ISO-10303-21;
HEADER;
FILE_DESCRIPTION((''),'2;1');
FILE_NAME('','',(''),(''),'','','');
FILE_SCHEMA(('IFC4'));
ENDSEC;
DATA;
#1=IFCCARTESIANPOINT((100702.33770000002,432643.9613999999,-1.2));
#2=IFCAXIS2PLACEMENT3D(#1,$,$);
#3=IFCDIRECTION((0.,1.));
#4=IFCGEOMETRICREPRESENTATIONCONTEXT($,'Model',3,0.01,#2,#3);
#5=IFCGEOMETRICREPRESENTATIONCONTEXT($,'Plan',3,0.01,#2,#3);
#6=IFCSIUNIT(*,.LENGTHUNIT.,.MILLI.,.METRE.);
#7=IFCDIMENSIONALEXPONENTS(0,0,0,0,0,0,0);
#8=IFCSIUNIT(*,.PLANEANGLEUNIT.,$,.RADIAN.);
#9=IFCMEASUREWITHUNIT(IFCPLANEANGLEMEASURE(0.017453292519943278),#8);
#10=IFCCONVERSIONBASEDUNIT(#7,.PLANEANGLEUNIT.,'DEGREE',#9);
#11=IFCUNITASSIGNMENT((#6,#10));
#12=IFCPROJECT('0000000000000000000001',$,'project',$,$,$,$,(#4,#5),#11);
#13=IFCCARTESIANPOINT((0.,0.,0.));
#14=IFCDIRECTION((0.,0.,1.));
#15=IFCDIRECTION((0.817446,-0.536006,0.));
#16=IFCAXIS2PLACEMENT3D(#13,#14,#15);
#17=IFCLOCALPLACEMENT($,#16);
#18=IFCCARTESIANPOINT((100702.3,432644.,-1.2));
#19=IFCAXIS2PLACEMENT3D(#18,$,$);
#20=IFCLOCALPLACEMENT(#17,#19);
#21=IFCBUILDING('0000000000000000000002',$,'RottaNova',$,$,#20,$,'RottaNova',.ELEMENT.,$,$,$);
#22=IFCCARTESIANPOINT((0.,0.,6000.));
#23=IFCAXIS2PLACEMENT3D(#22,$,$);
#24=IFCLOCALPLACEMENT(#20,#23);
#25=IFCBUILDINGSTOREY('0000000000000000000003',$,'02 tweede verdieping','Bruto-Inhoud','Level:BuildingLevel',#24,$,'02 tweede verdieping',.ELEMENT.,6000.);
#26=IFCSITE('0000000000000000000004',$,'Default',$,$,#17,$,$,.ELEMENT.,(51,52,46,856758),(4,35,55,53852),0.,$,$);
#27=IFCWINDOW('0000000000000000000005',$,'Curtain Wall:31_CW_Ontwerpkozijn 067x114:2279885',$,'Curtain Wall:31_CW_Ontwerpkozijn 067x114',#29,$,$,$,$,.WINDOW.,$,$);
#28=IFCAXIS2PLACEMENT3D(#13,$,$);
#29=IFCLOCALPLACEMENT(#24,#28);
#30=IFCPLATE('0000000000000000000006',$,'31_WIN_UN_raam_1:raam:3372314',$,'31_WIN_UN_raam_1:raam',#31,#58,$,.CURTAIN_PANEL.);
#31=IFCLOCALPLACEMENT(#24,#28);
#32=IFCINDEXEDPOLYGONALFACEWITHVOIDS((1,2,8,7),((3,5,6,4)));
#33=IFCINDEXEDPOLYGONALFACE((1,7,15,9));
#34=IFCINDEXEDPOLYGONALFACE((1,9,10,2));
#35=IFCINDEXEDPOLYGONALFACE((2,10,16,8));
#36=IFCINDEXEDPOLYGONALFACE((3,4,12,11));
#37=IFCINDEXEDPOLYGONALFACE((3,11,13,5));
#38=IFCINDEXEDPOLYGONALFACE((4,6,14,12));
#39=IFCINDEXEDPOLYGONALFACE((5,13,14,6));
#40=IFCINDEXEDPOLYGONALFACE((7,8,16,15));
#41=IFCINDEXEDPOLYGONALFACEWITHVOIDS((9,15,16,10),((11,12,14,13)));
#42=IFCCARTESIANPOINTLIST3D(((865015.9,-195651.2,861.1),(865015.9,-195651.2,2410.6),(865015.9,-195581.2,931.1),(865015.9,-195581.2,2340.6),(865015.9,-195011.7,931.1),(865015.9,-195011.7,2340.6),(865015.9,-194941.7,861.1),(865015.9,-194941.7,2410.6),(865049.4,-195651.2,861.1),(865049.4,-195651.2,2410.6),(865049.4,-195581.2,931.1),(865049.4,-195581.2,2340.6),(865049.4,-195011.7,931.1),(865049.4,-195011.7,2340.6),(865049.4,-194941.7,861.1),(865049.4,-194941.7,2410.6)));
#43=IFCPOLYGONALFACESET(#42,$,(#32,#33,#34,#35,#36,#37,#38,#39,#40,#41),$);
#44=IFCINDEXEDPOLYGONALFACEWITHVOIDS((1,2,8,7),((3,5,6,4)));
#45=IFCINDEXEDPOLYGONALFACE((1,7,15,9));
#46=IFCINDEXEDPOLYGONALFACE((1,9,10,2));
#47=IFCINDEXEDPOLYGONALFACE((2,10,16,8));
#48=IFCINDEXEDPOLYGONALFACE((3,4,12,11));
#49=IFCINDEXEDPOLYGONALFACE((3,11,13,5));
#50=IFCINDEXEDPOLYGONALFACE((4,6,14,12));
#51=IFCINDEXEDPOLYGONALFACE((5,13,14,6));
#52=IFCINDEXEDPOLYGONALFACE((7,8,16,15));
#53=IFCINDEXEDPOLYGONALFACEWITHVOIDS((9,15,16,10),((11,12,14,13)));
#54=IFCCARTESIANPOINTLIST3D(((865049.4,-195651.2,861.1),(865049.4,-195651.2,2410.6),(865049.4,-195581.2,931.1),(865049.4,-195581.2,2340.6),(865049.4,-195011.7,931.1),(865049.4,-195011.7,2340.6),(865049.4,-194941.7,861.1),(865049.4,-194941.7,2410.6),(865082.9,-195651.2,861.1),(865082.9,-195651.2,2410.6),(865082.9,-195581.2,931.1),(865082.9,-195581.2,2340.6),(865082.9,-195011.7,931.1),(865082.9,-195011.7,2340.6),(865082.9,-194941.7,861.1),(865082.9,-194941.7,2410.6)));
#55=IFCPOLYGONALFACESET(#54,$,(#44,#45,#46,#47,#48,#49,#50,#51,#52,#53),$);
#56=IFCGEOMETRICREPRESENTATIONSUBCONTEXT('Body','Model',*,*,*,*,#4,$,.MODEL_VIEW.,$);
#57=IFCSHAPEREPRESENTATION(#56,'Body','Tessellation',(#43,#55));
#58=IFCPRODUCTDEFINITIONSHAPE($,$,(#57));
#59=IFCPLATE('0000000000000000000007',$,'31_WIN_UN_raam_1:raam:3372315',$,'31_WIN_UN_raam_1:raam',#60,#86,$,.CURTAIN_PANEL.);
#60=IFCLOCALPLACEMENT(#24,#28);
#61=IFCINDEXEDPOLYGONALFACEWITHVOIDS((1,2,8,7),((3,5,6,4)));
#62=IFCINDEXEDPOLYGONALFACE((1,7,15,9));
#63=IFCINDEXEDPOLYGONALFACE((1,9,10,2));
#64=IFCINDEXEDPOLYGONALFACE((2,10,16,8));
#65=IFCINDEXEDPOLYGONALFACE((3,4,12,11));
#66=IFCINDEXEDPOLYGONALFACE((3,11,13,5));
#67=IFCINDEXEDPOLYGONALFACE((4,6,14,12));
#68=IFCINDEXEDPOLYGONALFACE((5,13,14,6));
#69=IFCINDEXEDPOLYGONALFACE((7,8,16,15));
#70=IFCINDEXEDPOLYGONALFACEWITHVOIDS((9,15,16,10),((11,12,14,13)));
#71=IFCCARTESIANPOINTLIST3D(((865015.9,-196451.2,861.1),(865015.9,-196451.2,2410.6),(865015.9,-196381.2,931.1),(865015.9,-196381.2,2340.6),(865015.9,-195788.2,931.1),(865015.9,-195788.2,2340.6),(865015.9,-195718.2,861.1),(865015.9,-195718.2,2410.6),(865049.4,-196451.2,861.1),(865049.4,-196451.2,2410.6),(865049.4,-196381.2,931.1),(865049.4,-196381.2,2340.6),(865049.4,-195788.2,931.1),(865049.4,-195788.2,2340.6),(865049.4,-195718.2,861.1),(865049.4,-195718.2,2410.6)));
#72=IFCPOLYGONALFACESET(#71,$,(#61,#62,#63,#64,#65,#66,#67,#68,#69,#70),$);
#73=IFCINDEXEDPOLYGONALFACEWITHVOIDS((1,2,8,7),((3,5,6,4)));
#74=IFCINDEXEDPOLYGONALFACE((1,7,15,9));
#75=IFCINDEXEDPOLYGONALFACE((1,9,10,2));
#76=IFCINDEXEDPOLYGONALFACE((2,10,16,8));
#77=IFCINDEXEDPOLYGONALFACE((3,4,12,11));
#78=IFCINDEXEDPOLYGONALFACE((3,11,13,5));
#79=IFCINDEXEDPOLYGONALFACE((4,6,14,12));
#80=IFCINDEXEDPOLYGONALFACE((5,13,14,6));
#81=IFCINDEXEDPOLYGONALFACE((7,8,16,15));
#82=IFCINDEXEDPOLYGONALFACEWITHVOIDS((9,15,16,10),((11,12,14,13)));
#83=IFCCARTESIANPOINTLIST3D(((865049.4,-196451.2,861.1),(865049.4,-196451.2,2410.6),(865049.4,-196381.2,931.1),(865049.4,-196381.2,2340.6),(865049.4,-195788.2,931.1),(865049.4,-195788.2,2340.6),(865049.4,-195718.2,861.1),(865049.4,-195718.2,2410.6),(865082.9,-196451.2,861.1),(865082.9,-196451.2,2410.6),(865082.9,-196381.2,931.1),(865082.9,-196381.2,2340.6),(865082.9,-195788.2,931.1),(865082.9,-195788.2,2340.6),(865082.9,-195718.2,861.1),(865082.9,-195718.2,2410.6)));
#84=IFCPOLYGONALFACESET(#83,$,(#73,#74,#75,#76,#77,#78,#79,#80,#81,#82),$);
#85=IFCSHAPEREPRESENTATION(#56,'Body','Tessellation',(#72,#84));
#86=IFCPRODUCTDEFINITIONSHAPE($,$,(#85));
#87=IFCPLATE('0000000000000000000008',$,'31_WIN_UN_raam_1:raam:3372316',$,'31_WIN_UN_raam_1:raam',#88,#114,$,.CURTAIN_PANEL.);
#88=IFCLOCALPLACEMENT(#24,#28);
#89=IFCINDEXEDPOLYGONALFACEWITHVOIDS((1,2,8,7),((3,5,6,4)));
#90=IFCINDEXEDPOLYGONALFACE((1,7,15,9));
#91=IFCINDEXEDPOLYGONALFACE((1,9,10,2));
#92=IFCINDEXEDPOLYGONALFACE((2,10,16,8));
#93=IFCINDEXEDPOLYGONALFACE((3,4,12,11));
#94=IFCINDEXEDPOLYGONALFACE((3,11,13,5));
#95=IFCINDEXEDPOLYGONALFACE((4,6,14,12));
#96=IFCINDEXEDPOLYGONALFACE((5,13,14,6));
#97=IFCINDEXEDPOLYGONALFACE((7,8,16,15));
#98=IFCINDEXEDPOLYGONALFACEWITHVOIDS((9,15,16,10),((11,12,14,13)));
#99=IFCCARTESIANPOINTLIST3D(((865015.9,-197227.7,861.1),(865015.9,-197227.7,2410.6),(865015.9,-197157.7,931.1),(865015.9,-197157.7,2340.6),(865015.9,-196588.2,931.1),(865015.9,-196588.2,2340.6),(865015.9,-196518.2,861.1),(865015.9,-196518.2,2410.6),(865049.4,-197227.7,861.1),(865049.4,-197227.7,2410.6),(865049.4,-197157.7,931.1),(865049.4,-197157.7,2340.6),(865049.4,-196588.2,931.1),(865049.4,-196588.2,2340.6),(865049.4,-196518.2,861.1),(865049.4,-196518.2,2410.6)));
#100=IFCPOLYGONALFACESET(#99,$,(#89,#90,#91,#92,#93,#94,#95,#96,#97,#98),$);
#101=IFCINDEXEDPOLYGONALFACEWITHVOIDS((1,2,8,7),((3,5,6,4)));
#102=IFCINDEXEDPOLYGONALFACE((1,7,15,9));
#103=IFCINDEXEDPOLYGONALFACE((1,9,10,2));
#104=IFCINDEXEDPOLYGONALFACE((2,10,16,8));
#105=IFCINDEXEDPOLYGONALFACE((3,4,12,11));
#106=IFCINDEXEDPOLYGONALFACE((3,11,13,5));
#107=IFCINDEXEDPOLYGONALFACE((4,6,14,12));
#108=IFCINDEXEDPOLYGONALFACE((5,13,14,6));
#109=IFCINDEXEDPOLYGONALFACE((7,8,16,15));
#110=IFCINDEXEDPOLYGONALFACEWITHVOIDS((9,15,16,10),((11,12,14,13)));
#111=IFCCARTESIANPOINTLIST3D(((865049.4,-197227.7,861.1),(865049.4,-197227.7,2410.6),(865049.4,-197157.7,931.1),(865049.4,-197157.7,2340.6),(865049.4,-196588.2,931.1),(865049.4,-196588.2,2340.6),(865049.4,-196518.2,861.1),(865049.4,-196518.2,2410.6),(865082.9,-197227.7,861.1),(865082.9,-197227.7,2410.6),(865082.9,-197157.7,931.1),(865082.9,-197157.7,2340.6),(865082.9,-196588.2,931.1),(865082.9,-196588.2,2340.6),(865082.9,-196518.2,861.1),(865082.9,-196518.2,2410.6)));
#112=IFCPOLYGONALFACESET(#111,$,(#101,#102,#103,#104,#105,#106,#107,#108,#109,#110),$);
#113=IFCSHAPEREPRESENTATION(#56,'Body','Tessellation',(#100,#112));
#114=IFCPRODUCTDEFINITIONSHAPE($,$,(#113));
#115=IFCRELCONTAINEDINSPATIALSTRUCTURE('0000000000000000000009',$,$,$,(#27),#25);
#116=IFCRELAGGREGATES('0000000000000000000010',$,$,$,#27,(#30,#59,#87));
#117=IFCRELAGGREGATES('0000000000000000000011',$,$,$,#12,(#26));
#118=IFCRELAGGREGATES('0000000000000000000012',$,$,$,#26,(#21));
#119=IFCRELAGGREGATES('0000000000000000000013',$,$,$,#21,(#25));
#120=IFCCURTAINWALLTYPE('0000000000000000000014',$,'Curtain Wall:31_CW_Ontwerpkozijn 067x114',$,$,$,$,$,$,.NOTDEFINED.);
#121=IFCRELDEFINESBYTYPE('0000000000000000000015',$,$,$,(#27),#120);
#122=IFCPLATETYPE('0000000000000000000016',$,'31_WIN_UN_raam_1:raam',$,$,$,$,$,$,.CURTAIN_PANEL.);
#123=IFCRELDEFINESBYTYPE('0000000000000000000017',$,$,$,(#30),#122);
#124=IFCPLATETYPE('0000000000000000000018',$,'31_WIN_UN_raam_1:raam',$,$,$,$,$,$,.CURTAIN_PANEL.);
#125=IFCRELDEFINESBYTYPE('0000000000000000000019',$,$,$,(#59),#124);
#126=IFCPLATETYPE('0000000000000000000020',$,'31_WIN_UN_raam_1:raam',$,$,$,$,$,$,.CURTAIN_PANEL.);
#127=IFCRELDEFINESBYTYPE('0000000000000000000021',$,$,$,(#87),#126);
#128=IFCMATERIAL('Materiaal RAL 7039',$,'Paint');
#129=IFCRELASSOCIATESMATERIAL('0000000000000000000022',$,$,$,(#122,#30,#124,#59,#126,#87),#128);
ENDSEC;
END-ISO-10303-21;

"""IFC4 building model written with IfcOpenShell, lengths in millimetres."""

from ifc_helpers import new_model, entity, si_unit, converted_unit, direction, frame, place, context, subcontext, project, spatial, indexed_curve, outline, extrude, source, transform, mapped, material, type_object, type_shapes, element, aggregate, save


model = new_model("IFC4")

# Units and contexts
model_context = context("Model", 3, precision=0.01, world=frame((100702.33770000002, 432643.9613999999, -1.2)), true_north=direction((0.0, 1.0)))
plan_context = context("Plan", 3, precision=0.01, world=frame((100702.33770000002, 432643.9613999999, -1.2)), true_north=direction((0.0, 1.0)))
body_context = subcontext(model_context, "Body", "Model", "MODEL_VIEW")
ifc_project = project(units=[si_unit("LENGTHUNIT", "METRE", prefix="MILLI"), converted_unit("PLANEANGLEUNIT", "DEGREE", entity("IfcPlaneAngleMeasure", 0.017453292519943278), si_unit("PLANEANGLEUNIT", "RADIAN"), dimensions=[0, 0, 0, 0, 0, 0, 0])], contexts=[model_context, plan_context])

# Site, building, storey
site_placement = place(None, frame((0.0, 0.0, 0.0), z_axis=(0.0, 0.0, 1.0), x_axis=(0.817446, -0.536006, 0.0)))
site = spatial("IfcSite", under=ifc_project, at=site_placement, Name="Default", CompositionType="ELEMENT", RefLatitude=(51, 52, 46, 856758), RefLongitude=(4, 35, 55, 53852), RefElevation=0.0)
building_placement = place(site_placement, frame((100702.3, 432644.0, -1.2)))
building = spatial("IfcBuilding", under=site, at=building_placement, Name="RottaNova", LongName="RottaNova", CompositionType="ELEMENT")
storey_placement = place(building_placement, frame((0.0, 0.0, 6000.0)))
storey = spatial("IfcBuildingStorey", under=building, at=storey_placement, Name="02 tweede verdieping", Description="Bruto-Inhoud", ObjectType="Level:BuildingLevel", LongName="02 tweede verdieping", CompositionType="ELEMENT", Elevation=6000.0)

# Window, plates
curtain_wall_type = type_object("IfcCurtainWallType", Name="Curtain Wall:31_CW_Ontwerpkozijn 067x114", PredefinedType="NOTDEFINED")
window_1_placement = place(storey_placement, frame((0.0, 0.0, -6000.0)))
window_1 = element("IfcWindow", 1, at=window_1_placement, inside=storey, type_object=curtain_wall_type, Name="Curtain Wall:31_CW_Ontwerpkozijn 067x114:2279885", ObjectType="Curtain Wall:31_CW_Ontwerpkozijn 067x114", PredefinedType="WINDOW")
ifc_material_1 = material(Name="Materiaal RAL 7039", Category="Paint")
plate_type_1 = type_object("IfcPlateType", Name="31_WIN_UN_raam_1:raam", PredefinedType="CURTAIN_PANEL", material=ifc_material_1)
shared_shape_1 = source(frame((100702.3, 432644.0, -1.2)), body_context, "Body", "SweptSolid", [
    extrude(outline(indexed_curve([(-354.7, -774.7), (354.7, -774.7), (354.7, 774.7), (-354.7, 774.7), (-354.7, -774.7)], self_intersect=False), holes=[indexed_curve([(-284.7, 704.7), (284.7, 704.7), (284.7, -704.8), (-284.7, -704.8), (-284.7, 704.7)], self_intersect=False)]), frame((0.0, -92.0, 774.8), z_axis=(0.0, 1.0, 0.0), x_axis=(1.0, 0.0, 0.0)), (0.0, 0.0, 1.0), 33.5),
    extrude(outline(indexed_curve([(-354.7, -774.7), (354.7, -774.7), (354.7, 774.7), (-354.7, 774.7), (-354.7, -774.7)], self_intersect=False), holes=[indexed_curve([(-284.7, 704.7), (284.7, 704.7), (284.7, -704.8), (-284.7, -704.8), (-284.7, 704.7)], self_intersect=False)]), frame((0.0, -58.5, 774.8), z_axis=(0.0, 1.0, 0.0), x_axis=(1.0, 0.0, 0.0)), (0.0, 0.0, 1.0), 33.5),
])
type_shapes(plate_type_1, [shared_shape_1])
plate_1_placement = place(window_1_placement, frame((-180.0, 6108.2, 6863.5), z_axis=(0.0, 0.0, 1.0), x_axis=(0.0, -1.0, 0.0)))
plate_1 = element("IfcPlate", 2, at=plate_1_placement, type_object=plate_type_1, material=ifc_material_1, Name="31_WIN_UN_raam_1:raam:3372314", ObjectType="31_WIN_UN_raam_1:raam", PredefinedType="CURTAIN_PANEL", context=body_context, shape_type="MappedRepresentation", body=[
    mapped(shared_shape_1, transform((100702.3, 432644.0, -1.2), scale=1.0)),
])
plate_type_2 = type_object("IfcPlateType", Name="31_WIN_UN_raam_1:raam", PredefinedType="CURTAIN_PANEL", material=ifc_material_1)
shared_shape_2 = source(frame((100702.3, 432644.0, -1.2)), body_context, "Body", "SweptSolid", [
    extrude(outline(indexed_curve([(-366.5, -774.7), (366.5, -774.7), (366.5, 774.7), (-366.5, 774.7), (-366.5, -774.7)], self_intersect=False), holes=[indexed_curve([(-296.5, 704.7), (296.5, 704.7), (296.5, -704.8), (-296.5, -704.8), (-296.5, 704.7)], self_intersect=False)]), frame((0.0, -92.0, 774.8), z_axis=(0.0, 1.0, 0.0), x_axis=(1.0, 0.0, 0.0)), (0.0, 0.0, 1.0), 33.5),
    extrude(outline(indexed_curve([(-366.5, -774.7), (366.5, -774.7), (366.5, 774.7), (-366.5, 774.7), (-366.5, -774.7)], self_intersect=False), holes=[indexed_curve([(-296.5, 704.7), (296.5, 704.7), (296.5, -704.8), (-296.5, -704.8), (-296.5, 704.7)], self_intersect=False)]), frame((0.0, -58.5, 774.8), z_axis=(0.0, 1.0, 0.0), x_axis=(1.0, 0.0, 0.0)), (0.0, 0.0, 1.0), 33.5),
])
type_shapes(plate_type_2, [shared_shape_2])
plate_2_placement = place(window_1_placement, frame((-180.0, 5320.0, 6863.5), z_axis=(0.0, 0.0, 1.0), x_axis=(0.0, -1.0, 0.0)))
plate_2 = element("IfcPlate", 3, at=plate_2_placement, type_object=plate_type_2, material=ifc_material_1, Name="31_WIN_UN_raam_1:raam:3372315", ObjectType="31_WIN_UN_raam_1:raam", PredefinedType="CURTAIN_PANEL", context=body_context, shape_type="MappedRepresentation", body=[
    mapped(shared_shape_2, transform((100702.3, 432644.0, -1.2), scale=1.0)),
])
plate_type_3 = type_object("IfcPlateType", Name="31_WIN_UN_raam_1:raam", PredefinedType="CURTAIN_PANEL", material=ifc_material_1)
shared_shape_3 = source(frame((100702.3, 432644.0, -1.2)), body_context, "Body", "SweptSolid", [
    extrude(outline(indexed_curve([(-354.7, -774.7), (354.7, -774.7), (354.7, 774.7), (-354.7, 774.7), (-354.7, -774.7)], self_intersect=False), holes=[indexed_curve([(-284.7, 704.7), (284.7, 704.7), (284.7, -704.8), (-284.7, -704.8), (-284.7, 704.7)], self_intersect=False)]), frame((0.0, -92.0, 774.8), z_axis=(0.0, 1.0, 0.0), x_axis=(1.0, 0.0, 0.0)), (0.0, 0.0, 1.0), 33.5),
    extrude(outline(indexed_curve([(-354.7, -774.7), (354.7, -774.7), (354.7, 774.7), (-354.7, 774.7), (-354.7, -774.7)], self_intersect=False), holes=[indexed_curve([(-284.7, 704.7), (284.7, 704.7), (284.7, -704.8), (-284.7, -704.8), (-284.7, 704.7)], self_intersect=False)]), frame((0.0, -58.5, 774.8), z_axis=(0.0, 1.0, 0.0), x_axis=(1.0, 0.0, 0.0)), (0.0, 0.0, 1.0), 33.5),
])
type_shapes(plate_type_3, [shared_shape_3])
plate_3_placement = place(window_1_placement, frame((-180.0, 4531.7, 6863.5), z_axis=(0.0, 0.0, 1.0), x_axis=(0.0, -1.0, 0.0)))
plate_3 = element("IfcPlate", 4, at=plate_3_placement, type_object=plate_type_3, material=ifc_material_1, Name="31_WIN_UN_raam_1:raam:3372316", ObjectType="31_WIN_UN_raam_1:raam", PredefinedType="CURTAIN_PANEL", context=body_context, shape_type="MappedRepresentation", body=[
    mapped(shared_shape_3, transform((100702.3, 432644.0, -1.2), scale=1.0)),
])
aggregate(window_1, [plate_1, plate_2, plate_3])

save(model, "model.ifc")
